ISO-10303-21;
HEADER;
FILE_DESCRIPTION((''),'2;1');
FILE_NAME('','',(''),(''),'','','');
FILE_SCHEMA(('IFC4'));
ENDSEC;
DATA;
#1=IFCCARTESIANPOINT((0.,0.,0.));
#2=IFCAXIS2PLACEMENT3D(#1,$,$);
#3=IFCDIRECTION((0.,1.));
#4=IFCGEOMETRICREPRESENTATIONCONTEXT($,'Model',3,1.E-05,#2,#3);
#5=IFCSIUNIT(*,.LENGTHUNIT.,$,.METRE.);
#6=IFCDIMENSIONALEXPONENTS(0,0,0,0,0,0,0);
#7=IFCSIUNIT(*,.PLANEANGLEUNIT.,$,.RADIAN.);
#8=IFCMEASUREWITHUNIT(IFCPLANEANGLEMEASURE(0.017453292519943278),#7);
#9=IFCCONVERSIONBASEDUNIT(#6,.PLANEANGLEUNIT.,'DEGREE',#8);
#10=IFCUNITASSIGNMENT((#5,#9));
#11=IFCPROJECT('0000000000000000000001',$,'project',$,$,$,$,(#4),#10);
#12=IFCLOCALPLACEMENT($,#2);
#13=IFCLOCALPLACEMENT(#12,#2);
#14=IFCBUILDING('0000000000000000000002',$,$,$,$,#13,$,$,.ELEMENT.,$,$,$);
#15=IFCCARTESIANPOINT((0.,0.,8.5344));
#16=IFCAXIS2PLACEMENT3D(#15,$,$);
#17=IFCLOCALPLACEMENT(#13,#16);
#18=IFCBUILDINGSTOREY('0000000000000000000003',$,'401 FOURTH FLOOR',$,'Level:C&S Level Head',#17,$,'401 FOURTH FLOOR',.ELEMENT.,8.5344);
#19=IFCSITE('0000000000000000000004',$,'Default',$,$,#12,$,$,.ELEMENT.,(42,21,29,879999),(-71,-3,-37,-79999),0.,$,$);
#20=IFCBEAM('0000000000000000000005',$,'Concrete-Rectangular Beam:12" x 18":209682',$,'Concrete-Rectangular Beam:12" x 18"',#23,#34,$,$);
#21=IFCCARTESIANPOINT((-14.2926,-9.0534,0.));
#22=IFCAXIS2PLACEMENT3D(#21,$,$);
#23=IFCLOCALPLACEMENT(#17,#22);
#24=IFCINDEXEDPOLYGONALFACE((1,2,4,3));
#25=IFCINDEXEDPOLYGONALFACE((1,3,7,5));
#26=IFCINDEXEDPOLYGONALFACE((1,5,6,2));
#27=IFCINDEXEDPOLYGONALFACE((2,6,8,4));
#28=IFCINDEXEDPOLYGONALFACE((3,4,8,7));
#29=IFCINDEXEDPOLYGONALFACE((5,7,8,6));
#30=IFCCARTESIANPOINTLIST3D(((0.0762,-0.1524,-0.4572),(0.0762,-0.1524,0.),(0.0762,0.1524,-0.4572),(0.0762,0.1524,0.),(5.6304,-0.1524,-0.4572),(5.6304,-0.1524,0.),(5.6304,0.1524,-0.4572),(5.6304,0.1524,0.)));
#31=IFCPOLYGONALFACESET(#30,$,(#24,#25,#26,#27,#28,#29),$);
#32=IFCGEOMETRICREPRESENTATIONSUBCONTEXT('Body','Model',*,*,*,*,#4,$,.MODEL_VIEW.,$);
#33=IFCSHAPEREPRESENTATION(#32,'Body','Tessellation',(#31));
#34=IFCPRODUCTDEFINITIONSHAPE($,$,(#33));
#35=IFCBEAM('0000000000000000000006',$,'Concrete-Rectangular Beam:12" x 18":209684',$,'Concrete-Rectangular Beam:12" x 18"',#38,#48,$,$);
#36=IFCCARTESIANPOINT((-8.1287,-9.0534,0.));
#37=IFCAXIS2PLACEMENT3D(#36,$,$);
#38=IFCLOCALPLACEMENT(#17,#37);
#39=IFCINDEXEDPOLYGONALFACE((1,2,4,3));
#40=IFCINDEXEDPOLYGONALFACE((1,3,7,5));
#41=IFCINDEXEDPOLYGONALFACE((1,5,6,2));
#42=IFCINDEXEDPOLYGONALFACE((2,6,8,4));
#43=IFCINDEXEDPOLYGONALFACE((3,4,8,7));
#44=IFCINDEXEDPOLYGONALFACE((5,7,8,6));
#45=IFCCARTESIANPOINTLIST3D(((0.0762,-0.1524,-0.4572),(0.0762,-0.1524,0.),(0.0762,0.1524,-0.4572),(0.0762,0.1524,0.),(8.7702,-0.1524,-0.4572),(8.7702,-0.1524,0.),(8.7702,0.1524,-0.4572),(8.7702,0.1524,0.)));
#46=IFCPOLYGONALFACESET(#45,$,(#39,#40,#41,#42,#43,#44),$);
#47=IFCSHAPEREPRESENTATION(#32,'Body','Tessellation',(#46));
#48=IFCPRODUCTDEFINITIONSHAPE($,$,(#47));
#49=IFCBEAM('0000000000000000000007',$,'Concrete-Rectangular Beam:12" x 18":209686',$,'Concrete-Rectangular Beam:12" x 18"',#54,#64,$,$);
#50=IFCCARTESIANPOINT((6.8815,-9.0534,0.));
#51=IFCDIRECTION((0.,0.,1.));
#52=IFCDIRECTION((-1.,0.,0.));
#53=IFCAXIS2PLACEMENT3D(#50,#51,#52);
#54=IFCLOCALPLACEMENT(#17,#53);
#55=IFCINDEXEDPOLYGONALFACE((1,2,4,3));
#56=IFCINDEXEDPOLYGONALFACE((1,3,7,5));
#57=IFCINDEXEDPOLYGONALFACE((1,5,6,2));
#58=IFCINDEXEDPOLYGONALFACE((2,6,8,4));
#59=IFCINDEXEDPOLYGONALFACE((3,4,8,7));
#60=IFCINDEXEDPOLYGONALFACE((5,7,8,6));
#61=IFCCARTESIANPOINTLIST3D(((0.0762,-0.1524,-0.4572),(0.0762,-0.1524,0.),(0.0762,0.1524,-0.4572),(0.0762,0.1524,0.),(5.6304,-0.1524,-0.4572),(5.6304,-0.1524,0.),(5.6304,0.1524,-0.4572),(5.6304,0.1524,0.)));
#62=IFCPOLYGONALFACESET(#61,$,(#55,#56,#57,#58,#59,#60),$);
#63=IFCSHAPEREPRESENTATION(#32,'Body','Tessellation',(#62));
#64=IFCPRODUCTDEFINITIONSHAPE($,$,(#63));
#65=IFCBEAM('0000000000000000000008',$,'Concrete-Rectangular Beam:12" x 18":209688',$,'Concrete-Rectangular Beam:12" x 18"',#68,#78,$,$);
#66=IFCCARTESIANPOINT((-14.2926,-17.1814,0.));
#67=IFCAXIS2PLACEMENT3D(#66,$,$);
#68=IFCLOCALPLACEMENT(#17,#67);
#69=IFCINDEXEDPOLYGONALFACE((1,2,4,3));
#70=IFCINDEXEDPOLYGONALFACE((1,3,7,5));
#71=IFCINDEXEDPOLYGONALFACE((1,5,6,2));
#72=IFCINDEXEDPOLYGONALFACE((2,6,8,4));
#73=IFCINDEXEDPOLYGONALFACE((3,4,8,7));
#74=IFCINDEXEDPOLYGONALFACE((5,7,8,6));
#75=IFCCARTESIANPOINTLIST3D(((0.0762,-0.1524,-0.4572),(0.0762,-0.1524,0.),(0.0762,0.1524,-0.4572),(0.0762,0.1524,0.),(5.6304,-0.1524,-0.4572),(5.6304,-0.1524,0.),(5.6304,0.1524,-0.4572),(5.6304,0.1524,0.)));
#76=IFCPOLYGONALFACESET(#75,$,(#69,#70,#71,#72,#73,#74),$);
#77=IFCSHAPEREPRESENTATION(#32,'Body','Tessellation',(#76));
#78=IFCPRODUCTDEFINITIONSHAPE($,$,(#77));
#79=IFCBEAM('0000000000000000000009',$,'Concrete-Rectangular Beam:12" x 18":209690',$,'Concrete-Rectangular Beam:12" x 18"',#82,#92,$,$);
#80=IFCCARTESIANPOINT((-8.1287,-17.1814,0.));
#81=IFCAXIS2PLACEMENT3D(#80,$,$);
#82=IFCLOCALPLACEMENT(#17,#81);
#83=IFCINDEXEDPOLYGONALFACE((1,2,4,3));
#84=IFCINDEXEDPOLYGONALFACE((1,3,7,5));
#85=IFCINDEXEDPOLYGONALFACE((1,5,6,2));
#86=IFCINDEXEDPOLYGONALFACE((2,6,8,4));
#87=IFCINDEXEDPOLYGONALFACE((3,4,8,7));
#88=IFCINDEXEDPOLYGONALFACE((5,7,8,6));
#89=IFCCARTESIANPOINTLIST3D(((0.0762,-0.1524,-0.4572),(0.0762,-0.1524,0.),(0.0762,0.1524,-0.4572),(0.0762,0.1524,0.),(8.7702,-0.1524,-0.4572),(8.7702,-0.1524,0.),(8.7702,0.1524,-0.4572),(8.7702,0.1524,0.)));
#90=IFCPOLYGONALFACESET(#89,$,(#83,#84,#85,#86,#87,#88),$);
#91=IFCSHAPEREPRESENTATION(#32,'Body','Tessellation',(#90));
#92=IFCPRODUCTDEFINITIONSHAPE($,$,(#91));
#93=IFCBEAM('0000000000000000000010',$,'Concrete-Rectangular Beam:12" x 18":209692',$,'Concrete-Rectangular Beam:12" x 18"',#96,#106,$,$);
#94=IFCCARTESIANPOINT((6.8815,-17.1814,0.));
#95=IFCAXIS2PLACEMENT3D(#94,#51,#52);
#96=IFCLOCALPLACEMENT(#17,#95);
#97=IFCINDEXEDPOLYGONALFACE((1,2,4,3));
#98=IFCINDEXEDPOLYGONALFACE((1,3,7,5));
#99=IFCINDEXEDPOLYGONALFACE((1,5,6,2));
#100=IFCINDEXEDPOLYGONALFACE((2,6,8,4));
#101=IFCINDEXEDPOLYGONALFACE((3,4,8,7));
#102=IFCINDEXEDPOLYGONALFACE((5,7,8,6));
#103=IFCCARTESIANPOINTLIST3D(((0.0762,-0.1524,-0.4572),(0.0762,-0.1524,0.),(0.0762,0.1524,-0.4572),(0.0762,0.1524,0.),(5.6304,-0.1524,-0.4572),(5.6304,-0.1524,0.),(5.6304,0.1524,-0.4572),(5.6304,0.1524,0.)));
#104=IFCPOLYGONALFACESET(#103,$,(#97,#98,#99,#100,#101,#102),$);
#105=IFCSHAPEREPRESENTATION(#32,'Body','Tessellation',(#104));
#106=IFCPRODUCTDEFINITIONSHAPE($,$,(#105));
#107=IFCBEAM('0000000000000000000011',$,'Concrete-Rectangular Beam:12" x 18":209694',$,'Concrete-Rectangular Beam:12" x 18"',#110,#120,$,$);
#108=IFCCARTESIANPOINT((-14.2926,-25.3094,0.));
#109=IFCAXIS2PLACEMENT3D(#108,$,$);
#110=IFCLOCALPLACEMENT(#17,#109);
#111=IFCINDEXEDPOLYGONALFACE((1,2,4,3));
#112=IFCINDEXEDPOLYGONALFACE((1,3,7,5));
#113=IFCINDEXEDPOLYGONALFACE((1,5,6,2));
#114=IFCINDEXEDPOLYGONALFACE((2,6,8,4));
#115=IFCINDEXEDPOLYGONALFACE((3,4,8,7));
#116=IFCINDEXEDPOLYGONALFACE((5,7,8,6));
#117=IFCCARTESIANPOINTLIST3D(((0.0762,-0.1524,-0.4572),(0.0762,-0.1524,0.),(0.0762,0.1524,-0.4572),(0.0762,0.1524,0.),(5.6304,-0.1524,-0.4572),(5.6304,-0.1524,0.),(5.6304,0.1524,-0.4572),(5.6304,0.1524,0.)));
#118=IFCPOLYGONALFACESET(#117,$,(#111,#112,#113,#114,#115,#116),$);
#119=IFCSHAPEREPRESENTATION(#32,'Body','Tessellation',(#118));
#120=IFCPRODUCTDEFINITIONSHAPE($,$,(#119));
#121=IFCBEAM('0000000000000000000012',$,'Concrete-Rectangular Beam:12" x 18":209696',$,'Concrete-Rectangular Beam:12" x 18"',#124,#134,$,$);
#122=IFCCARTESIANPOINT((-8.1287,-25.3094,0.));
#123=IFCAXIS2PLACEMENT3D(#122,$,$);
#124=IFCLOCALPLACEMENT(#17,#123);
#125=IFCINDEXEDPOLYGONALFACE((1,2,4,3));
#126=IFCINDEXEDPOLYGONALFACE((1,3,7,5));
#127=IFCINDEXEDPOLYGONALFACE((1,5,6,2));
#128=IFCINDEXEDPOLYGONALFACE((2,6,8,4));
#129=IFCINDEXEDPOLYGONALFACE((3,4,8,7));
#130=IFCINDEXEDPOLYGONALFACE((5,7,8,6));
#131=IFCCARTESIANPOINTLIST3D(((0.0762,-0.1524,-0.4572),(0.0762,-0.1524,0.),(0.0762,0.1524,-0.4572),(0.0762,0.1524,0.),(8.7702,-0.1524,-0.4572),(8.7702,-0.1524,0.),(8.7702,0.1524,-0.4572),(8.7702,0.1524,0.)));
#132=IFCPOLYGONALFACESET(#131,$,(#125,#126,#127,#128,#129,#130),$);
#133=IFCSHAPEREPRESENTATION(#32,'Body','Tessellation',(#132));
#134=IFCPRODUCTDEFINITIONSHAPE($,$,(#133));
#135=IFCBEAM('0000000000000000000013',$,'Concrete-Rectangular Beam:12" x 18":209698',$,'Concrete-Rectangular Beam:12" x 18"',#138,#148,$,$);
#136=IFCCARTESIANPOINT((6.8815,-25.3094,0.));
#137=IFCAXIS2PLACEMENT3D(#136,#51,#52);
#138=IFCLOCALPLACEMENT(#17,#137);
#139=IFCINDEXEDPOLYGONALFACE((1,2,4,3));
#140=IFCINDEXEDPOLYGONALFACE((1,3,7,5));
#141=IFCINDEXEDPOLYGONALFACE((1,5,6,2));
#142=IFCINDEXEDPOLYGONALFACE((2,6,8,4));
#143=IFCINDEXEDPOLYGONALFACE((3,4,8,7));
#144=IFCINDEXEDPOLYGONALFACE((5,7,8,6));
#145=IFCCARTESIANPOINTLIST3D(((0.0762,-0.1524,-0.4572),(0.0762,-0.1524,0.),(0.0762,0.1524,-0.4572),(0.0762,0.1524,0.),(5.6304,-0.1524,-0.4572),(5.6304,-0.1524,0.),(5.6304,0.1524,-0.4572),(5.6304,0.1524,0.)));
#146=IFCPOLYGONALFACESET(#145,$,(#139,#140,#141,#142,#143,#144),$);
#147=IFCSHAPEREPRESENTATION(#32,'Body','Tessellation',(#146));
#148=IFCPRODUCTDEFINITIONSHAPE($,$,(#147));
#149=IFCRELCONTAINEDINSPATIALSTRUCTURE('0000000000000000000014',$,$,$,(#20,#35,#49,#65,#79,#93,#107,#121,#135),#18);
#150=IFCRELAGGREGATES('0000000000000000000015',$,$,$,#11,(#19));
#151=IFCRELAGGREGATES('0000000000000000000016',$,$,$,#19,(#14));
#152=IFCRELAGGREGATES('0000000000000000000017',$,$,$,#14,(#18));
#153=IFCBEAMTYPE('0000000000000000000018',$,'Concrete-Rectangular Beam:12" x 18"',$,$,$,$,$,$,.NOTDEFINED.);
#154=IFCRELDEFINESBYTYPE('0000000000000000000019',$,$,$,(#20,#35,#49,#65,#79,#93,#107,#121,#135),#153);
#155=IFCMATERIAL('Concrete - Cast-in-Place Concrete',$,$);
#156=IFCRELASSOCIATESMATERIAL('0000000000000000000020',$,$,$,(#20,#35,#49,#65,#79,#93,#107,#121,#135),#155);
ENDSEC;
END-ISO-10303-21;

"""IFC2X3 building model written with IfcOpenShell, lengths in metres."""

from ifc_helpers import new_model, entity, si_unit, converted_unit, direction, frame, frame_2d, origin, origin_2d_with_axis, place, context, subcontext, project, spatial, rectangle, extrude, material, type_object, element, save


model = new_model("IFC2X3")

# Units and contexts
model_context = context("Model", 3, precision=1e-05, world=origin(), true_north=direction((0.0, 1.0)))
body_context = subcontext(model_context, "Body", "Model", "MODEL_VIEW")
ifc_project = project(units=[si_unit("LENGTHUNIT", "METRE"), converted_unit("PLANEANGLEUNIT", "DEGREE", entity("IfcPlaneAngleMeasure", 0.017453292519943278), si_unit("PLANEANGLEUNIT", "RADIAN"), dimensions=[0, 0, 0, 0, 0, 0, 0])], contexts=[model_context])

# Site, building, storey
site_placement = place(None, origin())
site = spatial("IfcSite", under=ifc_project, at=site_placement, Name="Default", CompositionType="ELEMENT", RefLatitude=(42, 21, 29, 879999), RefLongitude=(-71, -3, -37, -79999), RefElevation=0.0)
building_placement = place(site_placement, origin())
building = spatial("IfcBuilding", under=site, at=building_placement, CompositionType="ELEMENT")
storey_placement = place(building_placement, frame((0.0, 0.0, 8.5344)))
storey = spatial("IfcBuildingStorey", under=building, at=storey_placement, Name="401 FOURTH FLOOR", ObjectType="Level:C&S Level Head", LongName="401 FOURTH FLOOR", CompositionType="ELEMENT", Elevation=8.5344)

# Beams
ifc_material = material(Name="Concrete - Cast-in-Place Concrete")
beam_type = type_object("IfcBeamType", Name="Concrete-Rectangular Beam:12\" x 18\"", PredefinedType="NOTDEFINED")
beam_1_placement = place(storey_placement, frame((-14.2926, -9.0534, 0.0)))
element("IfcBeam", 1, at=beam_1_placement, inside=storey, type_object=beam_type, material=ifc_material, Name="Concrete-Rectangular Beam:12\" x 18\":209682", ObjectType="Concrete-Rectangular Beam:12\" x 18\"", context=body_context, shape_type="SweptSolid", body=[
    extrude(rectangle(XDim=0.4572, YDim=0.3048, at=frame_2d((0.0, 0.0), x_axis=(1.0, 0.0))), frame((0.0762, 0.0, -0.2286), z_axis=(1.0, 0.0, 0.0), x_axis=(0.0, 0.0, -1.0)), (0.0, 0.0, 1.0), 5.5542),
])
beam_2_placement = place(storey_placement, frame((-8.1287, -9.0534, 0.0)))
element("IfcBeam", 2, at=beam_2_placement, inside=storey, type_object=beam_type, material=ifc_material, Name="Concrete-Rectangular Beam:12\" x 18\":209684", ObjectType="Concrete-Rectangular Beam:12\" x 18\"", context=body_context, shape_type="SweptSolid", body=[
    extrude(rectangle(XDim=0.4572, YDim=0.3048, at=frame_2d((0.0, 0.0), x_axis=(1.0, 0.0))), frame((0.0762, 0.0, -0.2286), z_axis=(1.0, 0.0, 0.0), x_axis=(0.0, 0.0, -1.0)), (0.0, 0.0, 1.0), 8.694),
])
beam_3_placement = place(storey_placement, frame((6.8815, -9.0534, 0.0), z_axis=(0.0, 0.0, 1.0), x_axis=(-1.0, 0.0, 0.0)))
element("IfcBeam", 3, at=beam_3_placement, inside=storey, type_object=beam_type, material=ifc_material, Name="Concrete-Rectangular Beam:12\" x 18\":209686", ObjectType="Concrete-Rectangular Beam:12\" x 18\"", context=body_context, shape_type="SweptSolid", body=[
    extrude(rectangle(XDim=0.4572, YDim=0.3048, at=frame_2d((0.0, 0.0), x_axis=(1.0, 0.0))), frame((0.0762, 0.0, -0.2286), z_axis=(1.0, 0.0, 0.0), x_axis=(0.0, 0.0, -1.0)), (0.0, 0.0, 1.0), 5.5542),
])
beam_4_placement = place(storey_placement, frame((-14.2926, -17.1814, 0.0)))
element("IfcBeam", 4, at=beam_4_placement, inside=storey, type_object=beam_type, material=ifc_material, Name="Concrete-Rectangular Beam:12\" x 18\":209688", ObjectType="Concrete-Rectangular Beam:12\" x 18\"", context=body_context, shape_type="SweptSolid", body=[
    extrude(rectangle(XDim=0.4572, YDim=0.3048, at=origin_2d_with_axis()), frame((0.0762, 0.0, -0.2286), z_axis=(1.0, 0.0, 0.0), x_axis=(0.0, 0.0, -1.0)), (0.0, 0.0, 1.0), 5.5542),
])
beam_5_placement = place(storey_placement, frame((-8.1287, -17.1814, 0.0)))
element("IfcBeam", 5, at=beam_5_placement, inside=storey, type_object=beam_type, material=ifc_material, Name="Concrete-Rectangular Beam:12\" x 18\":209690", ObjectType="Concrete-Rectangular Beam:12\" x 18\"", context=body_context, shape_type="SweptSolid", body=[
    extrude(rectangle(XDim=0.4572, YDim=0.3048, at=origin_2d_with_axis()), frame((0.0762, 0.0, -0.2286), z_axis=(1.0, 0.0, 0.0), x_axis=(0.0, 0.0, -1.0)), (0.0, 0.0, 1.0), 8.694),
])
beam_6_placement = place(storey_placement, frame((6.8815, -17.1814, 0.0), z_axis=(0.0, 0.0, 1.0), x_axis=(-1.0, 0.0, 0.0)))
element("IfcBeam", 6, at=beam_6_placement, inside=storey, type_object=beam_type, material=ifc_material, Name="Concrete-Rectangular Beam:12\" x 18\":209692", ObjectType="Concrete-Rectangular Beam:12\" x 18\"", context=body_context, shape_type="SweptSolid", body=[
    extrude(rectangle(XDim=0.4572, YDim=0.3048, at=origin_2d_with_axis()), frame((0.0762, 0.0, -0.2286), z_axis=(1.0, 0.0, 0.0), x_axis=(0.0, 0.0, -1.0)), (0.0, 0.0, 1.0), 5.5542),
])
beam_7_placement = place(storey_placement, frame((-14.2926, -25.3094, 0.0)))
element("IfcBeam", 7, at=beam_7_placement, inside=storey, type_object=beam_type, material=ifc_material, Name="Concrete-Rectangular Beam:12\" x 18\":209694", ObjectType="Concrete-Rectangular Beam:12\" x 18\"", context=body_context, shape_type="SweptSolid", body=[
    extrude(rectangle(XDim=0.4572, YDim=0.3048, at=frame_2d((0.0, 0.0), x_axis=(1.0, 0.0))), frame((0.0762, 0.0, -0.2286), z_axis=(1.0, 0.0, 0.0), x_axis=(0.0, 0.0, -1.0)), (0.0, 0.0, 1.0), 5.5542),
])
beam_8_placement = place(storey_placement, frame((-8.1287, -25.3094, 0.0)))
element("IfcBeam", 8, at=beam_8_placement, inside=storey, type_object=beam_type, material=ifc_material, Name="Concrete-Rectangular Beam:12\" x 18\":209696", ObjectType="Concrete-Rectangular Beam:12\" x 18\"", context=body_context, shape_type="SweptSolid", body=[
    extrude(rectangle(XDim=0.4572, YDim=0.3048, at=origin_2d_with_axis()), frame((0.0762, 0.0, -0.2286), z_axis=(1.0, 0.0, 0.0), x_axis=(0.0, 0.0, -1.0)), (0.0, 0.0, 1.0), 8.694),
])
beam_9_placement = place(storey_placement, frame((6.8815, -25.3094, 0.0), z_axis=(0.0, 0.0, 1.0), x_axis=(-1.0, 0.0, 0.0)))
element("IfcBeam", 9, at=beam_9_placement, inside=storey, type_object=beam_type, material=ifc_material, Name="Concrete-Rectangular Beam:12\" x 18\":209698", ObjectType="Concrete-Rectangular Beam:12\" x 18\"", context=body_context, shape_type="SweptSolid", body=[
    extrude(rectangle(XDim=0.4572, YDim=0.3048, at=frame_2d((0.0, 0.0), x_axis=(1.0, 0.0))), frame((0.0762, 0.0, -0.2286), z_axis=(1.0, 0.0, 0.0), x_axis=(0.0, 0.0, -1.0)), (0.0, 0.0, 1.0), 5.5542),
])

save(model, "model.ifc")
